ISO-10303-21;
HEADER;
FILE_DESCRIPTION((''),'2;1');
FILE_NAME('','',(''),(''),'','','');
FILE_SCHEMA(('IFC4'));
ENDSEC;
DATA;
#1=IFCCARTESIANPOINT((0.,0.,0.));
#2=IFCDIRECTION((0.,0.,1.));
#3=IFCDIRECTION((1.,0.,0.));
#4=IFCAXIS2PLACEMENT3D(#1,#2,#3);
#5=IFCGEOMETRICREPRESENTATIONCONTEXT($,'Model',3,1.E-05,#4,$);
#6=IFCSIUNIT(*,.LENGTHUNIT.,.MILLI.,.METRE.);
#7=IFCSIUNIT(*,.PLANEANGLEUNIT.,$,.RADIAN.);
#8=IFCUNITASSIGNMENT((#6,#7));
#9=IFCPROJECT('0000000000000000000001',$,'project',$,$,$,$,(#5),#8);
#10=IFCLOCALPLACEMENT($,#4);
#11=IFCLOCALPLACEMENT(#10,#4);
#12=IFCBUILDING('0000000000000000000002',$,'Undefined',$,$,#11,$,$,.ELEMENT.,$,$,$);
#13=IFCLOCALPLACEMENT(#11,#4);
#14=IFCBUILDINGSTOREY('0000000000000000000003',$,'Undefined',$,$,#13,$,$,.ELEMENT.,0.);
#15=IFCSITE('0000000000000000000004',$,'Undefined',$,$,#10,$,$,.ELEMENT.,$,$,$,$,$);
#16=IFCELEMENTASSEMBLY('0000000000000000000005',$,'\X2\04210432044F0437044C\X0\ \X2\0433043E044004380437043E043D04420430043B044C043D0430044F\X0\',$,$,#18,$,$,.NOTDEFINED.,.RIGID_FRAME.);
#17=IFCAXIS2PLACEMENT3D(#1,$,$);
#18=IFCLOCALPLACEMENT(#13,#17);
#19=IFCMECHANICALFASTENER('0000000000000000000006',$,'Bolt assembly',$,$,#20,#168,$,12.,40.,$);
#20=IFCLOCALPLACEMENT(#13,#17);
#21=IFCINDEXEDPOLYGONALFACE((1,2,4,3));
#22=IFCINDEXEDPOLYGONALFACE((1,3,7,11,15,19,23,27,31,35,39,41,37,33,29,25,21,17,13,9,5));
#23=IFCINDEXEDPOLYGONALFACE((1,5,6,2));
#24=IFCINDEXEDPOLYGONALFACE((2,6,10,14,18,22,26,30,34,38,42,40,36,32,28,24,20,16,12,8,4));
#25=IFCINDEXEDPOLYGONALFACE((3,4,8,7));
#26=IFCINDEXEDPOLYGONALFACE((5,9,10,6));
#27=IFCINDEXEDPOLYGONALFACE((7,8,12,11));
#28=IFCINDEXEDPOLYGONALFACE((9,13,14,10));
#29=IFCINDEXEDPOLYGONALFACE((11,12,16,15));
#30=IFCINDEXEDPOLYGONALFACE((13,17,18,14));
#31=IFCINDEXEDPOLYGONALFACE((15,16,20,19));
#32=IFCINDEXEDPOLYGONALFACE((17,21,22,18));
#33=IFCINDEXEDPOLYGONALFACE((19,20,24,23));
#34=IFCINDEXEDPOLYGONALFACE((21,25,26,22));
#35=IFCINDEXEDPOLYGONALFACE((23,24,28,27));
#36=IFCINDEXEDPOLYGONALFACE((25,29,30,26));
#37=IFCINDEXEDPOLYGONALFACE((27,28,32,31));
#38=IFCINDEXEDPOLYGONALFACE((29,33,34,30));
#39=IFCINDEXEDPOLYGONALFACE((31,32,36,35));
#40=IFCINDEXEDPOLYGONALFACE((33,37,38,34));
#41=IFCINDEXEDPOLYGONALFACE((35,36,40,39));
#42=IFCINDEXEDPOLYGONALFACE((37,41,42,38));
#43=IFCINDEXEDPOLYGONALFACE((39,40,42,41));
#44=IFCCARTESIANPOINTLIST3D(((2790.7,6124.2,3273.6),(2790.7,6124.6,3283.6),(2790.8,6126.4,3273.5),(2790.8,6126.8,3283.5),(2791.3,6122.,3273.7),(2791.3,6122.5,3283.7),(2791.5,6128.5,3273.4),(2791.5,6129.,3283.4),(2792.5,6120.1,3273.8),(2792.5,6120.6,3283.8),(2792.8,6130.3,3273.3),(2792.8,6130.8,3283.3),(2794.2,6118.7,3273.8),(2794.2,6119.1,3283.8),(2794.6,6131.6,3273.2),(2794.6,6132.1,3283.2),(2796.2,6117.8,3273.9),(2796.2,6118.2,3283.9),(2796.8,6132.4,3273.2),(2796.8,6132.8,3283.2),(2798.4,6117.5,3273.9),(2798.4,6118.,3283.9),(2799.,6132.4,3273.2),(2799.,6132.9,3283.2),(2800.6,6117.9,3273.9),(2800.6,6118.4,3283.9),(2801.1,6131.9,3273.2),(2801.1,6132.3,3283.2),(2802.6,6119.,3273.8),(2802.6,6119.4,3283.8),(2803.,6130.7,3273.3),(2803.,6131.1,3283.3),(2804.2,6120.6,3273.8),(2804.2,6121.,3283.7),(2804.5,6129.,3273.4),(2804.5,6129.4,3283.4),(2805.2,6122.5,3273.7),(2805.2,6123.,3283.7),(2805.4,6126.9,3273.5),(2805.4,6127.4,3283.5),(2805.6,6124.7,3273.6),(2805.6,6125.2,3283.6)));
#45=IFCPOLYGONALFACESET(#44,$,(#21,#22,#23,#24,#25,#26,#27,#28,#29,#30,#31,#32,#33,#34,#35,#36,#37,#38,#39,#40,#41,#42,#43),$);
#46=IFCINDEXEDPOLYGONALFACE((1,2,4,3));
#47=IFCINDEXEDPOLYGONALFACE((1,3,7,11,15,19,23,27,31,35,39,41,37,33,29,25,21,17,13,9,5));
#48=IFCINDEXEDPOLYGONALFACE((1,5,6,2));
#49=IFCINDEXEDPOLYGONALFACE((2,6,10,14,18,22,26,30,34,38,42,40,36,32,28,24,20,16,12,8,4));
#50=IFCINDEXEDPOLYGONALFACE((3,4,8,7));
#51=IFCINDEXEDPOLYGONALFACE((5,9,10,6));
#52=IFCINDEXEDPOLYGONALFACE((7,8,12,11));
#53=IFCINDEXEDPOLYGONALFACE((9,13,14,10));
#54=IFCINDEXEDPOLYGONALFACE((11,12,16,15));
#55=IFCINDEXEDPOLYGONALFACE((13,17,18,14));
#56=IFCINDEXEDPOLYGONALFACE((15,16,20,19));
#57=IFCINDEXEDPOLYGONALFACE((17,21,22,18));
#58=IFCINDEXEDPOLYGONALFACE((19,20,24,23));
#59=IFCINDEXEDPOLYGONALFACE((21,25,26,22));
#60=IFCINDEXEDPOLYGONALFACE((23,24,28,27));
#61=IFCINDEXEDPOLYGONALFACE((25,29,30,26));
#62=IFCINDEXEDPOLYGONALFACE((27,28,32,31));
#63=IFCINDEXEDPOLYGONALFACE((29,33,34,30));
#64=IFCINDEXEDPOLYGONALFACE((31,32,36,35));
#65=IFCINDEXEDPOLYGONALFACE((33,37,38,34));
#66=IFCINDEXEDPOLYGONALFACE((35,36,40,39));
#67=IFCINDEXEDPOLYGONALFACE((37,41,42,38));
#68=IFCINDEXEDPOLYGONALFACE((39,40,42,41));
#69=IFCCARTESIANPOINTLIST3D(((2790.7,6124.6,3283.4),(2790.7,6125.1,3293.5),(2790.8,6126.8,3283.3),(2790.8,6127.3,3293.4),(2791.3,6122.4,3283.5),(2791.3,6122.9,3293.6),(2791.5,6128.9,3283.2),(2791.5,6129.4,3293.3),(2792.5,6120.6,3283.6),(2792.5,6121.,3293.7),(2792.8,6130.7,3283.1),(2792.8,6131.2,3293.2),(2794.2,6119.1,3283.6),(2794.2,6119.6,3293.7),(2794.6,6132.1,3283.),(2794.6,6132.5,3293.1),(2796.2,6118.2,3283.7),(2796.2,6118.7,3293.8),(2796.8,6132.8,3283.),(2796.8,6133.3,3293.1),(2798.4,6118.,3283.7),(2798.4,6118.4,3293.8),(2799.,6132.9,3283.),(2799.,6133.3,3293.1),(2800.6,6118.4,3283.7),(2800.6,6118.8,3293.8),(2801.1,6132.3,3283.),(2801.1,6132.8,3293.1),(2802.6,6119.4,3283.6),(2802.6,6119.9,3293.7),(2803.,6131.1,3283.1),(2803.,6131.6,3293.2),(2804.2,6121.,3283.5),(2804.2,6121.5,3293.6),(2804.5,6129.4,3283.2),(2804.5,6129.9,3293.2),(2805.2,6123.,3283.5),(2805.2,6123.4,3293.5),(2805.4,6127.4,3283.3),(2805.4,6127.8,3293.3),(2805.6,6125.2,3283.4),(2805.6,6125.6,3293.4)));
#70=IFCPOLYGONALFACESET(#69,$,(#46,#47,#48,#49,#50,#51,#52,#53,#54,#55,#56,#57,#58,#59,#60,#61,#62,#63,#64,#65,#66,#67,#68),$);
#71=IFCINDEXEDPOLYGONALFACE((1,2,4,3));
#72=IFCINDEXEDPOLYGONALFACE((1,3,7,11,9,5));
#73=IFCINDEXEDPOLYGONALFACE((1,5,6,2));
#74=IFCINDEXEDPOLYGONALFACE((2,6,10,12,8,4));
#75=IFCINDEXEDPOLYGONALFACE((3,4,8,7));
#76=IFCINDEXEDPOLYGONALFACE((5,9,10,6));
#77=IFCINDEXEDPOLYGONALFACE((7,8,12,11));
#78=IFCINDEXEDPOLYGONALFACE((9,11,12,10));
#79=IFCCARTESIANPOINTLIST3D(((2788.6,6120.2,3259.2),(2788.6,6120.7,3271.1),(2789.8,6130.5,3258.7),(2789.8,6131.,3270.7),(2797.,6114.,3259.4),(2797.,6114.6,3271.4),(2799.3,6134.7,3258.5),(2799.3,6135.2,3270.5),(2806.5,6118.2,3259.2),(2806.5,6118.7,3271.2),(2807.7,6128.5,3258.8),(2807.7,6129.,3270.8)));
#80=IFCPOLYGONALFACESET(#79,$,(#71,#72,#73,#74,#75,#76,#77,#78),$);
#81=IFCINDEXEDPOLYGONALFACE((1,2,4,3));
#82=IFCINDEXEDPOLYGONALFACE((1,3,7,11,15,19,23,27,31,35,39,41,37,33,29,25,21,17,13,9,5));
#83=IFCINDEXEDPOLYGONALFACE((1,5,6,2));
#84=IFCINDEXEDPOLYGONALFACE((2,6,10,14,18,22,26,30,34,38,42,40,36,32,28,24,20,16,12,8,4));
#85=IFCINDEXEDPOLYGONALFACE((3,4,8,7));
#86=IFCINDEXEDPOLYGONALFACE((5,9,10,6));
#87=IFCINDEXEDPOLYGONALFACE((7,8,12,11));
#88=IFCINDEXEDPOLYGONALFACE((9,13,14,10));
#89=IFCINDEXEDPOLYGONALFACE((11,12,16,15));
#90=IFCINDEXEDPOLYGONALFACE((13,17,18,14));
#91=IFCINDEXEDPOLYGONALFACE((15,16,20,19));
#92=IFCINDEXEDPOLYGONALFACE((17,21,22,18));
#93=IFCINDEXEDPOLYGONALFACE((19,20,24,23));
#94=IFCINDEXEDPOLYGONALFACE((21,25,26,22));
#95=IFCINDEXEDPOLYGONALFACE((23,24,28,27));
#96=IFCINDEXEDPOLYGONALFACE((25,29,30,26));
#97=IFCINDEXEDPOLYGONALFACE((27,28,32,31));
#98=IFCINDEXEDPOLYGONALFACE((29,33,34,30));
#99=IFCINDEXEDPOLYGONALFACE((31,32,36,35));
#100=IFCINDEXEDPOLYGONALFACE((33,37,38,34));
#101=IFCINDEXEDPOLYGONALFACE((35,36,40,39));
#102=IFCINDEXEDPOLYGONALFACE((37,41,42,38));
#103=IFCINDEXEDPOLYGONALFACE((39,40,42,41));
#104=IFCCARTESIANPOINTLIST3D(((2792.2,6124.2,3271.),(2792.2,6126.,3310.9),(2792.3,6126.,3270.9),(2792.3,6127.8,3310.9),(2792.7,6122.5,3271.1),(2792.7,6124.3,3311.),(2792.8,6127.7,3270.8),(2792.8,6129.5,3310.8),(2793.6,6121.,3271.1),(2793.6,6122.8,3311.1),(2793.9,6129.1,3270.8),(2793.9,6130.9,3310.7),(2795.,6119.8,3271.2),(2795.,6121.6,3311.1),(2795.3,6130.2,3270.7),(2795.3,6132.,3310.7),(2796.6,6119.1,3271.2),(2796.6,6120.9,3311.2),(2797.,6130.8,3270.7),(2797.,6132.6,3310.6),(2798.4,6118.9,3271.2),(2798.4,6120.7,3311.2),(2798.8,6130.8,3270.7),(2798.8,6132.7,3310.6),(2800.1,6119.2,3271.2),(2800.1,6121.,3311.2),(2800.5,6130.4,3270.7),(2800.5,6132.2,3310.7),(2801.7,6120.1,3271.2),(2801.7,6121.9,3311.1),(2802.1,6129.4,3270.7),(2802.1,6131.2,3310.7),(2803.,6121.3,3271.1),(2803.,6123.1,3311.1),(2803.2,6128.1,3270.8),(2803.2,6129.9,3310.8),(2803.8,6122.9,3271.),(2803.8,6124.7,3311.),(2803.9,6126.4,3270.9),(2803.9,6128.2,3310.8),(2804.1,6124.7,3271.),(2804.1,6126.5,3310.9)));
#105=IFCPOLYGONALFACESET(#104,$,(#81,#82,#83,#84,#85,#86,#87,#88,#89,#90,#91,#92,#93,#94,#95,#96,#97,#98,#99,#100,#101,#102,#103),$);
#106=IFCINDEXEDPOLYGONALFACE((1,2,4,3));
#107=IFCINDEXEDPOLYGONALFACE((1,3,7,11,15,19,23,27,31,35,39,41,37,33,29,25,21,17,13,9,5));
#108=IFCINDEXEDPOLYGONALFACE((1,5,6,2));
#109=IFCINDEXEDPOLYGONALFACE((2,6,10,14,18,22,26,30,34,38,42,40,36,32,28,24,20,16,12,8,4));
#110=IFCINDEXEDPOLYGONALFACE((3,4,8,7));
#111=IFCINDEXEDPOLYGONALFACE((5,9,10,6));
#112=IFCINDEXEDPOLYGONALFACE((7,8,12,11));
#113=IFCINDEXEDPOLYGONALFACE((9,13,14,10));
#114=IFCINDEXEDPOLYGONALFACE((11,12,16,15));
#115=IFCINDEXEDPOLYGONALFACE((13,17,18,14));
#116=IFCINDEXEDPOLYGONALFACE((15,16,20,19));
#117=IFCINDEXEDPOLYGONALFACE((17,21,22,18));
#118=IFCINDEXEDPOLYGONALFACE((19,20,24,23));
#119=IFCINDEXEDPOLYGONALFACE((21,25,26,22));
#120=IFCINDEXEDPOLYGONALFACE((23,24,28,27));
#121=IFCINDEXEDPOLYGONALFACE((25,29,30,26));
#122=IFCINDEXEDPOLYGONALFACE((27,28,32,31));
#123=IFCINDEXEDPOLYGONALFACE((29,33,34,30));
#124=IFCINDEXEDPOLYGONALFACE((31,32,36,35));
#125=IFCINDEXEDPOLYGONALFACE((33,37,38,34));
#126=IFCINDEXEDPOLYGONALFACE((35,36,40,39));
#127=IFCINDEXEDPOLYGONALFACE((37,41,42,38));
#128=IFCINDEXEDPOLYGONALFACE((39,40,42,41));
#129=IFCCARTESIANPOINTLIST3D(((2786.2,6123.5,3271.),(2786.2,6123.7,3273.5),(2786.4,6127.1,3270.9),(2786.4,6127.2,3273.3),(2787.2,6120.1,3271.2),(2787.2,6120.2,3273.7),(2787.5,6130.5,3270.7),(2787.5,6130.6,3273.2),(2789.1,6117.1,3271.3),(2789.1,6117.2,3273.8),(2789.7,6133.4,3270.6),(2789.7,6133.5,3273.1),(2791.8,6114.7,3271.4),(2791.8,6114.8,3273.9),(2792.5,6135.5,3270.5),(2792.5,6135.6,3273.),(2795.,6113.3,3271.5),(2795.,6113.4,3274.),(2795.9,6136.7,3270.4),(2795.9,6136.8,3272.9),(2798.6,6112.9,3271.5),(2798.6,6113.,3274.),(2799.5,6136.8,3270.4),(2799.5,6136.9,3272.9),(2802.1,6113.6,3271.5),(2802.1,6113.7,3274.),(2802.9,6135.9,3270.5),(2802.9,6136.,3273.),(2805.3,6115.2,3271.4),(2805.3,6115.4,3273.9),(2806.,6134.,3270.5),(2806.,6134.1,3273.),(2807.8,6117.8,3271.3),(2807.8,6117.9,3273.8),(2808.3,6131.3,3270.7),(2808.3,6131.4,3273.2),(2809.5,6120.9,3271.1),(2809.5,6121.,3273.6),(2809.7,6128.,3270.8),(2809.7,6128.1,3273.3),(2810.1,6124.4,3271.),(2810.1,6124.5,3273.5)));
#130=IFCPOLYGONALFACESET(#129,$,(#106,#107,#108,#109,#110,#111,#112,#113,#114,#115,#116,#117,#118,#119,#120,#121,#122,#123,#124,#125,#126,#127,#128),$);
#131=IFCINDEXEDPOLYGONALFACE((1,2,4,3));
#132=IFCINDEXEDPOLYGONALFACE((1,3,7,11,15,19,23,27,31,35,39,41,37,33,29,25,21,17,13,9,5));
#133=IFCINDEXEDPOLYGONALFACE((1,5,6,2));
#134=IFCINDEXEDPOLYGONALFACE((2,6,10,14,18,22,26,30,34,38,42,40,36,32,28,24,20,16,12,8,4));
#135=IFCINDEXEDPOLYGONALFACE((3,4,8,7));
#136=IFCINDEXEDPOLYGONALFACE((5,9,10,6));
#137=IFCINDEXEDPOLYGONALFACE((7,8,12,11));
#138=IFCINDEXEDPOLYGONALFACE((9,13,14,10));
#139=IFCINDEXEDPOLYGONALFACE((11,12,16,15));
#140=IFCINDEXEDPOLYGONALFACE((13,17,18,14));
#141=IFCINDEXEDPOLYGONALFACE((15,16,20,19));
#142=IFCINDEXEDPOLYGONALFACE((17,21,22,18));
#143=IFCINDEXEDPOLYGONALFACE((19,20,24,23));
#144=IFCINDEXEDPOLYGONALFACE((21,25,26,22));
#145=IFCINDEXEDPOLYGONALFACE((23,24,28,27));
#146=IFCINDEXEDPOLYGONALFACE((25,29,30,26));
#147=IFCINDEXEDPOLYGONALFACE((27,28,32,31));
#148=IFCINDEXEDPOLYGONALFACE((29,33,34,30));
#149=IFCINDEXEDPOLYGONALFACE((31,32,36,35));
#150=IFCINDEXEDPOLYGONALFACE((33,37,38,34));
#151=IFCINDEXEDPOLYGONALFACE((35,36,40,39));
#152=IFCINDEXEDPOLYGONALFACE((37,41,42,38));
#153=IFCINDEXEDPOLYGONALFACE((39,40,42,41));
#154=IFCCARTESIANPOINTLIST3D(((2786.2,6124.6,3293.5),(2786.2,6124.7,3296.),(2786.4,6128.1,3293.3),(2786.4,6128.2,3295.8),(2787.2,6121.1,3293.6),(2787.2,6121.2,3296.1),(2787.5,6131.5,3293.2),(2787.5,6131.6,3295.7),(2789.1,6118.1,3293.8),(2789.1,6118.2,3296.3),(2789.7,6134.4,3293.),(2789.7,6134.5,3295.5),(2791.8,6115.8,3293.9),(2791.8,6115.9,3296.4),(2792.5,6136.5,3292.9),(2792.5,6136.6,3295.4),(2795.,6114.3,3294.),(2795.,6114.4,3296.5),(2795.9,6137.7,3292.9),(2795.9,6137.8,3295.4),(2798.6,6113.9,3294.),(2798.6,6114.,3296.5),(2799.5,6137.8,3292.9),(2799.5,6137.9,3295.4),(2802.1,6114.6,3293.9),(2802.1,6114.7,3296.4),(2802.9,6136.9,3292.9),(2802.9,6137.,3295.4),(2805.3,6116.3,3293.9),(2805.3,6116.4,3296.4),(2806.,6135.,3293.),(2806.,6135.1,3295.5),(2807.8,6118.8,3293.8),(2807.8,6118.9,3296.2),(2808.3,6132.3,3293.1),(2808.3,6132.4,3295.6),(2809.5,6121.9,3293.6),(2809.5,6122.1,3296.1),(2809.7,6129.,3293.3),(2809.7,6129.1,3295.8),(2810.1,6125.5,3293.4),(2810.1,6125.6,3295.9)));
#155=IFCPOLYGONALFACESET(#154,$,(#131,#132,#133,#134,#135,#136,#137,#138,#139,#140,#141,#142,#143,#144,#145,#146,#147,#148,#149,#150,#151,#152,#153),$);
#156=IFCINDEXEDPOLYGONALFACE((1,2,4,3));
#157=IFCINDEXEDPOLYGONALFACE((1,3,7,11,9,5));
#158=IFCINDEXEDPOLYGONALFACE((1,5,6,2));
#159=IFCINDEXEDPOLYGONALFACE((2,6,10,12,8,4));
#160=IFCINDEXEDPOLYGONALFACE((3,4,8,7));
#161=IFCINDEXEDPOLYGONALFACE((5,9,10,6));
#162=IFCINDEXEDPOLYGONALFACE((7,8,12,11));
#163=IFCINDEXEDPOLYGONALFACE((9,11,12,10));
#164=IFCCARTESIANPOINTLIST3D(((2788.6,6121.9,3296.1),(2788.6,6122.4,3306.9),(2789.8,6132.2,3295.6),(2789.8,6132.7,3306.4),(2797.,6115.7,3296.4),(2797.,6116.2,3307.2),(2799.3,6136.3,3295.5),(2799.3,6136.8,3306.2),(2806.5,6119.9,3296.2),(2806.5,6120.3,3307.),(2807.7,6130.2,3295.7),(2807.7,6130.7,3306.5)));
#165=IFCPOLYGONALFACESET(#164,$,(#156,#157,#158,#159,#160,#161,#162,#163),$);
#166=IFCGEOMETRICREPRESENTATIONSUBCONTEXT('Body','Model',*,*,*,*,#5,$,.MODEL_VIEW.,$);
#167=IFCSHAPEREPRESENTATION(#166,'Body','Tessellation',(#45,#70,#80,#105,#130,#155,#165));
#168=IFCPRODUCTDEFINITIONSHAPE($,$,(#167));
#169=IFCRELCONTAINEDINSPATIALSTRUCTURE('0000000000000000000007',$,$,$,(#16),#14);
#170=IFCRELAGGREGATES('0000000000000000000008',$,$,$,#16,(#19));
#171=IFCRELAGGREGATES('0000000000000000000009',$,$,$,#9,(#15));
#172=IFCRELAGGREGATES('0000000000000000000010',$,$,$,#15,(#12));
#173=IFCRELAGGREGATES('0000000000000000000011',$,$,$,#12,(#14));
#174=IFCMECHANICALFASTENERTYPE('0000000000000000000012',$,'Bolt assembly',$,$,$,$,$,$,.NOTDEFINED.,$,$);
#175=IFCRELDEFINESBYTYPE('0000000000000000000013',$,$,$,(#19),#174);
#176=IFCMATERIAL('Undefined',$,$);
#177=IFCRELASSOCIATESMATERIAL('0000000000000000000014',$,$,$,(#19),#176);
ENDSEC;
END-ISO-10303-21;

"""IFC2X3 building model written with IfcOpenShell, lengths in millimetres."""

from ifc_helpers import new_model, si_unit, frame, origin_with_axes, origin_2d_with_axis, place, context, subcontext, project, spatial, polyline, circle, outline, extrude, source, transform, mapped, material, type_object, element, aggregate, save


model = new_model("IFC2X3")

# Units and contexts
model_context = context("Model", 3, precision=1e-05, world=origin_with_axes())
body_context = subcontext(model_context, "Body", "Model", "MODEL_VIEW")
ifc_project = project(units=[si_unit("LENGTHUNIT", "METRE", prefix="MILLI"), si_unit("PLANEANGLEUNIT", "RADIAN")], contexts=[model_context])

# Site, building, storey
site_placement = place(None, origin_with_axes())
site = spatial("IfcSite", under=ifc_project, at=site_placement, Name="Undefined", CompositionType="ELEMENT")
building_placement = place(site_placement, origin_with_axes())
building = spatial("IfcBuilding", under=site, at=building_placement, Name="Undefined", CompositionType="ELEMENT")
storey_placement = place(building_placement, origin_with_axes())
storey = spatial("IfcBuildingStorey", under=building, at=storey_placement, Name="Undefined", CompositionType="ELEMENT", Elevation=0.0)

# Element assembly
assembly_1_placement = place(storey_placement, origin_with_axes())
assembly_1 = element("IfcElementAssembly", 1, at=assembly_1_placement, inside=storey, Name="Связь горизонтальная", AssemblyPlace="NOTDEFINED", PredefinedType="RIGID_FRAME")

# Mechanical fastener
ifc_material_1 = material(Name="Undefined")
mechanical_fastener_type = type_object("IfcMechanicalFastenerType", Name="Bolt assembly")
shared_shape_1 = source(origin_with_axes(), body_context, "Body", "SweptSolid", [
    extrude(circle(Radius=7.5, at=origin_2d_with_axis()), frame((0.0, 0.1, 0.0), z_axis=(0.0, 1.0, 0.0), x_axis=(1.0, 0.0, 0.0)), (0.0, 0.0, 1.0), 10.0),
    extrude(circle(Radius=7.5, at=origin_2d_with_axis()), frame((0.0, 9.9, 0.0), z_axis=(0.0, 1.0, 0.0), x_axis=(1.0, 0.0, 0.0)), (0.0, 0.0, 1.0), 10.1),
    extrude(outline(polyline([(10.4, 0.0), (5.2, 9.0), (-5.2, 9.0), (-10.4, 0.0), (-5.2, -9.0), (5.2, -9.0), (10.4, 0.0)])), frame((0.0, -14.5, 0.0), z_axis=(0.0, 1.0, 0.0), x_axis=(1.0, 0.0, 0.0)), (0.0, 0.0, 1.0), 12.0),
    extrude(circle(Radius=6.0, at=origin_2d_with_axis()), frame((0.0, -2.5, 0.0), z_axis=(0.0, 1.0, 0.0), x_axis=(1.0, 0.0, 0.0)), (0.0, 0.0, 1.0), 40.0),
    extrude(circle(Radius=12.0, at=origin_2d_with_axis()), frame((0.0, -2.5, 0.0), z_axis=(0.0, 1.0, 0.0), x_axis=(1.0, 0.0, 0.0)), (0.0, 0.0, 1.0), 2.5),
    extrude(circle(Radius=12.0, at=origin_2d_with_axis()), frame((0.0, 20.0, 0.0), z_axis=(0.0, 1.0, 0.0), x_axis=(1.0, 0.0, 0.0)), (0.0, 0.0, 1.0), 2.5),
    extrude(outline(polyline([(10.4, 0.0), (5.2, 9.0), (-5.2, 9.0), (-10.4, 0.0), (-5.2, -9.0), (5.2, -9.0), (10.4, 0.0)])), frame((0.0, 22.5, 0.0), z_axis=(0.0, 1.0, 0.0), x_axis=(1.0, 0.0, 0.0)), (0.0, 0.0, 1.0), 10.8),
])
mechanical_fastener_1_placement = place(assembly_1_placement, frame((2798.1, 6125.0, 3273.4), z_axis=(-0.593795, -0.803786, 0.036536), x_axis=(0.804616, -0.593183, 0.026963)))
mechanical_fastener_1 = element("IfcMechanicalFastener", 2, at=mechanical_fastener_1_placement, type_object=mechanical_fastener_type, material=ifc_material_1, Name="Bolt assembly", NominalDiameter=12.0, NominalLength=40.0, context=body_context, shape_type="MappedRepresentation", body=[
    mapped(shared_shape_1, transform((0.0, 0.0, 0.0))),
])
aggregate(assembly_1, [mechanical_fastener_1])

save(model, "model.ifc")
